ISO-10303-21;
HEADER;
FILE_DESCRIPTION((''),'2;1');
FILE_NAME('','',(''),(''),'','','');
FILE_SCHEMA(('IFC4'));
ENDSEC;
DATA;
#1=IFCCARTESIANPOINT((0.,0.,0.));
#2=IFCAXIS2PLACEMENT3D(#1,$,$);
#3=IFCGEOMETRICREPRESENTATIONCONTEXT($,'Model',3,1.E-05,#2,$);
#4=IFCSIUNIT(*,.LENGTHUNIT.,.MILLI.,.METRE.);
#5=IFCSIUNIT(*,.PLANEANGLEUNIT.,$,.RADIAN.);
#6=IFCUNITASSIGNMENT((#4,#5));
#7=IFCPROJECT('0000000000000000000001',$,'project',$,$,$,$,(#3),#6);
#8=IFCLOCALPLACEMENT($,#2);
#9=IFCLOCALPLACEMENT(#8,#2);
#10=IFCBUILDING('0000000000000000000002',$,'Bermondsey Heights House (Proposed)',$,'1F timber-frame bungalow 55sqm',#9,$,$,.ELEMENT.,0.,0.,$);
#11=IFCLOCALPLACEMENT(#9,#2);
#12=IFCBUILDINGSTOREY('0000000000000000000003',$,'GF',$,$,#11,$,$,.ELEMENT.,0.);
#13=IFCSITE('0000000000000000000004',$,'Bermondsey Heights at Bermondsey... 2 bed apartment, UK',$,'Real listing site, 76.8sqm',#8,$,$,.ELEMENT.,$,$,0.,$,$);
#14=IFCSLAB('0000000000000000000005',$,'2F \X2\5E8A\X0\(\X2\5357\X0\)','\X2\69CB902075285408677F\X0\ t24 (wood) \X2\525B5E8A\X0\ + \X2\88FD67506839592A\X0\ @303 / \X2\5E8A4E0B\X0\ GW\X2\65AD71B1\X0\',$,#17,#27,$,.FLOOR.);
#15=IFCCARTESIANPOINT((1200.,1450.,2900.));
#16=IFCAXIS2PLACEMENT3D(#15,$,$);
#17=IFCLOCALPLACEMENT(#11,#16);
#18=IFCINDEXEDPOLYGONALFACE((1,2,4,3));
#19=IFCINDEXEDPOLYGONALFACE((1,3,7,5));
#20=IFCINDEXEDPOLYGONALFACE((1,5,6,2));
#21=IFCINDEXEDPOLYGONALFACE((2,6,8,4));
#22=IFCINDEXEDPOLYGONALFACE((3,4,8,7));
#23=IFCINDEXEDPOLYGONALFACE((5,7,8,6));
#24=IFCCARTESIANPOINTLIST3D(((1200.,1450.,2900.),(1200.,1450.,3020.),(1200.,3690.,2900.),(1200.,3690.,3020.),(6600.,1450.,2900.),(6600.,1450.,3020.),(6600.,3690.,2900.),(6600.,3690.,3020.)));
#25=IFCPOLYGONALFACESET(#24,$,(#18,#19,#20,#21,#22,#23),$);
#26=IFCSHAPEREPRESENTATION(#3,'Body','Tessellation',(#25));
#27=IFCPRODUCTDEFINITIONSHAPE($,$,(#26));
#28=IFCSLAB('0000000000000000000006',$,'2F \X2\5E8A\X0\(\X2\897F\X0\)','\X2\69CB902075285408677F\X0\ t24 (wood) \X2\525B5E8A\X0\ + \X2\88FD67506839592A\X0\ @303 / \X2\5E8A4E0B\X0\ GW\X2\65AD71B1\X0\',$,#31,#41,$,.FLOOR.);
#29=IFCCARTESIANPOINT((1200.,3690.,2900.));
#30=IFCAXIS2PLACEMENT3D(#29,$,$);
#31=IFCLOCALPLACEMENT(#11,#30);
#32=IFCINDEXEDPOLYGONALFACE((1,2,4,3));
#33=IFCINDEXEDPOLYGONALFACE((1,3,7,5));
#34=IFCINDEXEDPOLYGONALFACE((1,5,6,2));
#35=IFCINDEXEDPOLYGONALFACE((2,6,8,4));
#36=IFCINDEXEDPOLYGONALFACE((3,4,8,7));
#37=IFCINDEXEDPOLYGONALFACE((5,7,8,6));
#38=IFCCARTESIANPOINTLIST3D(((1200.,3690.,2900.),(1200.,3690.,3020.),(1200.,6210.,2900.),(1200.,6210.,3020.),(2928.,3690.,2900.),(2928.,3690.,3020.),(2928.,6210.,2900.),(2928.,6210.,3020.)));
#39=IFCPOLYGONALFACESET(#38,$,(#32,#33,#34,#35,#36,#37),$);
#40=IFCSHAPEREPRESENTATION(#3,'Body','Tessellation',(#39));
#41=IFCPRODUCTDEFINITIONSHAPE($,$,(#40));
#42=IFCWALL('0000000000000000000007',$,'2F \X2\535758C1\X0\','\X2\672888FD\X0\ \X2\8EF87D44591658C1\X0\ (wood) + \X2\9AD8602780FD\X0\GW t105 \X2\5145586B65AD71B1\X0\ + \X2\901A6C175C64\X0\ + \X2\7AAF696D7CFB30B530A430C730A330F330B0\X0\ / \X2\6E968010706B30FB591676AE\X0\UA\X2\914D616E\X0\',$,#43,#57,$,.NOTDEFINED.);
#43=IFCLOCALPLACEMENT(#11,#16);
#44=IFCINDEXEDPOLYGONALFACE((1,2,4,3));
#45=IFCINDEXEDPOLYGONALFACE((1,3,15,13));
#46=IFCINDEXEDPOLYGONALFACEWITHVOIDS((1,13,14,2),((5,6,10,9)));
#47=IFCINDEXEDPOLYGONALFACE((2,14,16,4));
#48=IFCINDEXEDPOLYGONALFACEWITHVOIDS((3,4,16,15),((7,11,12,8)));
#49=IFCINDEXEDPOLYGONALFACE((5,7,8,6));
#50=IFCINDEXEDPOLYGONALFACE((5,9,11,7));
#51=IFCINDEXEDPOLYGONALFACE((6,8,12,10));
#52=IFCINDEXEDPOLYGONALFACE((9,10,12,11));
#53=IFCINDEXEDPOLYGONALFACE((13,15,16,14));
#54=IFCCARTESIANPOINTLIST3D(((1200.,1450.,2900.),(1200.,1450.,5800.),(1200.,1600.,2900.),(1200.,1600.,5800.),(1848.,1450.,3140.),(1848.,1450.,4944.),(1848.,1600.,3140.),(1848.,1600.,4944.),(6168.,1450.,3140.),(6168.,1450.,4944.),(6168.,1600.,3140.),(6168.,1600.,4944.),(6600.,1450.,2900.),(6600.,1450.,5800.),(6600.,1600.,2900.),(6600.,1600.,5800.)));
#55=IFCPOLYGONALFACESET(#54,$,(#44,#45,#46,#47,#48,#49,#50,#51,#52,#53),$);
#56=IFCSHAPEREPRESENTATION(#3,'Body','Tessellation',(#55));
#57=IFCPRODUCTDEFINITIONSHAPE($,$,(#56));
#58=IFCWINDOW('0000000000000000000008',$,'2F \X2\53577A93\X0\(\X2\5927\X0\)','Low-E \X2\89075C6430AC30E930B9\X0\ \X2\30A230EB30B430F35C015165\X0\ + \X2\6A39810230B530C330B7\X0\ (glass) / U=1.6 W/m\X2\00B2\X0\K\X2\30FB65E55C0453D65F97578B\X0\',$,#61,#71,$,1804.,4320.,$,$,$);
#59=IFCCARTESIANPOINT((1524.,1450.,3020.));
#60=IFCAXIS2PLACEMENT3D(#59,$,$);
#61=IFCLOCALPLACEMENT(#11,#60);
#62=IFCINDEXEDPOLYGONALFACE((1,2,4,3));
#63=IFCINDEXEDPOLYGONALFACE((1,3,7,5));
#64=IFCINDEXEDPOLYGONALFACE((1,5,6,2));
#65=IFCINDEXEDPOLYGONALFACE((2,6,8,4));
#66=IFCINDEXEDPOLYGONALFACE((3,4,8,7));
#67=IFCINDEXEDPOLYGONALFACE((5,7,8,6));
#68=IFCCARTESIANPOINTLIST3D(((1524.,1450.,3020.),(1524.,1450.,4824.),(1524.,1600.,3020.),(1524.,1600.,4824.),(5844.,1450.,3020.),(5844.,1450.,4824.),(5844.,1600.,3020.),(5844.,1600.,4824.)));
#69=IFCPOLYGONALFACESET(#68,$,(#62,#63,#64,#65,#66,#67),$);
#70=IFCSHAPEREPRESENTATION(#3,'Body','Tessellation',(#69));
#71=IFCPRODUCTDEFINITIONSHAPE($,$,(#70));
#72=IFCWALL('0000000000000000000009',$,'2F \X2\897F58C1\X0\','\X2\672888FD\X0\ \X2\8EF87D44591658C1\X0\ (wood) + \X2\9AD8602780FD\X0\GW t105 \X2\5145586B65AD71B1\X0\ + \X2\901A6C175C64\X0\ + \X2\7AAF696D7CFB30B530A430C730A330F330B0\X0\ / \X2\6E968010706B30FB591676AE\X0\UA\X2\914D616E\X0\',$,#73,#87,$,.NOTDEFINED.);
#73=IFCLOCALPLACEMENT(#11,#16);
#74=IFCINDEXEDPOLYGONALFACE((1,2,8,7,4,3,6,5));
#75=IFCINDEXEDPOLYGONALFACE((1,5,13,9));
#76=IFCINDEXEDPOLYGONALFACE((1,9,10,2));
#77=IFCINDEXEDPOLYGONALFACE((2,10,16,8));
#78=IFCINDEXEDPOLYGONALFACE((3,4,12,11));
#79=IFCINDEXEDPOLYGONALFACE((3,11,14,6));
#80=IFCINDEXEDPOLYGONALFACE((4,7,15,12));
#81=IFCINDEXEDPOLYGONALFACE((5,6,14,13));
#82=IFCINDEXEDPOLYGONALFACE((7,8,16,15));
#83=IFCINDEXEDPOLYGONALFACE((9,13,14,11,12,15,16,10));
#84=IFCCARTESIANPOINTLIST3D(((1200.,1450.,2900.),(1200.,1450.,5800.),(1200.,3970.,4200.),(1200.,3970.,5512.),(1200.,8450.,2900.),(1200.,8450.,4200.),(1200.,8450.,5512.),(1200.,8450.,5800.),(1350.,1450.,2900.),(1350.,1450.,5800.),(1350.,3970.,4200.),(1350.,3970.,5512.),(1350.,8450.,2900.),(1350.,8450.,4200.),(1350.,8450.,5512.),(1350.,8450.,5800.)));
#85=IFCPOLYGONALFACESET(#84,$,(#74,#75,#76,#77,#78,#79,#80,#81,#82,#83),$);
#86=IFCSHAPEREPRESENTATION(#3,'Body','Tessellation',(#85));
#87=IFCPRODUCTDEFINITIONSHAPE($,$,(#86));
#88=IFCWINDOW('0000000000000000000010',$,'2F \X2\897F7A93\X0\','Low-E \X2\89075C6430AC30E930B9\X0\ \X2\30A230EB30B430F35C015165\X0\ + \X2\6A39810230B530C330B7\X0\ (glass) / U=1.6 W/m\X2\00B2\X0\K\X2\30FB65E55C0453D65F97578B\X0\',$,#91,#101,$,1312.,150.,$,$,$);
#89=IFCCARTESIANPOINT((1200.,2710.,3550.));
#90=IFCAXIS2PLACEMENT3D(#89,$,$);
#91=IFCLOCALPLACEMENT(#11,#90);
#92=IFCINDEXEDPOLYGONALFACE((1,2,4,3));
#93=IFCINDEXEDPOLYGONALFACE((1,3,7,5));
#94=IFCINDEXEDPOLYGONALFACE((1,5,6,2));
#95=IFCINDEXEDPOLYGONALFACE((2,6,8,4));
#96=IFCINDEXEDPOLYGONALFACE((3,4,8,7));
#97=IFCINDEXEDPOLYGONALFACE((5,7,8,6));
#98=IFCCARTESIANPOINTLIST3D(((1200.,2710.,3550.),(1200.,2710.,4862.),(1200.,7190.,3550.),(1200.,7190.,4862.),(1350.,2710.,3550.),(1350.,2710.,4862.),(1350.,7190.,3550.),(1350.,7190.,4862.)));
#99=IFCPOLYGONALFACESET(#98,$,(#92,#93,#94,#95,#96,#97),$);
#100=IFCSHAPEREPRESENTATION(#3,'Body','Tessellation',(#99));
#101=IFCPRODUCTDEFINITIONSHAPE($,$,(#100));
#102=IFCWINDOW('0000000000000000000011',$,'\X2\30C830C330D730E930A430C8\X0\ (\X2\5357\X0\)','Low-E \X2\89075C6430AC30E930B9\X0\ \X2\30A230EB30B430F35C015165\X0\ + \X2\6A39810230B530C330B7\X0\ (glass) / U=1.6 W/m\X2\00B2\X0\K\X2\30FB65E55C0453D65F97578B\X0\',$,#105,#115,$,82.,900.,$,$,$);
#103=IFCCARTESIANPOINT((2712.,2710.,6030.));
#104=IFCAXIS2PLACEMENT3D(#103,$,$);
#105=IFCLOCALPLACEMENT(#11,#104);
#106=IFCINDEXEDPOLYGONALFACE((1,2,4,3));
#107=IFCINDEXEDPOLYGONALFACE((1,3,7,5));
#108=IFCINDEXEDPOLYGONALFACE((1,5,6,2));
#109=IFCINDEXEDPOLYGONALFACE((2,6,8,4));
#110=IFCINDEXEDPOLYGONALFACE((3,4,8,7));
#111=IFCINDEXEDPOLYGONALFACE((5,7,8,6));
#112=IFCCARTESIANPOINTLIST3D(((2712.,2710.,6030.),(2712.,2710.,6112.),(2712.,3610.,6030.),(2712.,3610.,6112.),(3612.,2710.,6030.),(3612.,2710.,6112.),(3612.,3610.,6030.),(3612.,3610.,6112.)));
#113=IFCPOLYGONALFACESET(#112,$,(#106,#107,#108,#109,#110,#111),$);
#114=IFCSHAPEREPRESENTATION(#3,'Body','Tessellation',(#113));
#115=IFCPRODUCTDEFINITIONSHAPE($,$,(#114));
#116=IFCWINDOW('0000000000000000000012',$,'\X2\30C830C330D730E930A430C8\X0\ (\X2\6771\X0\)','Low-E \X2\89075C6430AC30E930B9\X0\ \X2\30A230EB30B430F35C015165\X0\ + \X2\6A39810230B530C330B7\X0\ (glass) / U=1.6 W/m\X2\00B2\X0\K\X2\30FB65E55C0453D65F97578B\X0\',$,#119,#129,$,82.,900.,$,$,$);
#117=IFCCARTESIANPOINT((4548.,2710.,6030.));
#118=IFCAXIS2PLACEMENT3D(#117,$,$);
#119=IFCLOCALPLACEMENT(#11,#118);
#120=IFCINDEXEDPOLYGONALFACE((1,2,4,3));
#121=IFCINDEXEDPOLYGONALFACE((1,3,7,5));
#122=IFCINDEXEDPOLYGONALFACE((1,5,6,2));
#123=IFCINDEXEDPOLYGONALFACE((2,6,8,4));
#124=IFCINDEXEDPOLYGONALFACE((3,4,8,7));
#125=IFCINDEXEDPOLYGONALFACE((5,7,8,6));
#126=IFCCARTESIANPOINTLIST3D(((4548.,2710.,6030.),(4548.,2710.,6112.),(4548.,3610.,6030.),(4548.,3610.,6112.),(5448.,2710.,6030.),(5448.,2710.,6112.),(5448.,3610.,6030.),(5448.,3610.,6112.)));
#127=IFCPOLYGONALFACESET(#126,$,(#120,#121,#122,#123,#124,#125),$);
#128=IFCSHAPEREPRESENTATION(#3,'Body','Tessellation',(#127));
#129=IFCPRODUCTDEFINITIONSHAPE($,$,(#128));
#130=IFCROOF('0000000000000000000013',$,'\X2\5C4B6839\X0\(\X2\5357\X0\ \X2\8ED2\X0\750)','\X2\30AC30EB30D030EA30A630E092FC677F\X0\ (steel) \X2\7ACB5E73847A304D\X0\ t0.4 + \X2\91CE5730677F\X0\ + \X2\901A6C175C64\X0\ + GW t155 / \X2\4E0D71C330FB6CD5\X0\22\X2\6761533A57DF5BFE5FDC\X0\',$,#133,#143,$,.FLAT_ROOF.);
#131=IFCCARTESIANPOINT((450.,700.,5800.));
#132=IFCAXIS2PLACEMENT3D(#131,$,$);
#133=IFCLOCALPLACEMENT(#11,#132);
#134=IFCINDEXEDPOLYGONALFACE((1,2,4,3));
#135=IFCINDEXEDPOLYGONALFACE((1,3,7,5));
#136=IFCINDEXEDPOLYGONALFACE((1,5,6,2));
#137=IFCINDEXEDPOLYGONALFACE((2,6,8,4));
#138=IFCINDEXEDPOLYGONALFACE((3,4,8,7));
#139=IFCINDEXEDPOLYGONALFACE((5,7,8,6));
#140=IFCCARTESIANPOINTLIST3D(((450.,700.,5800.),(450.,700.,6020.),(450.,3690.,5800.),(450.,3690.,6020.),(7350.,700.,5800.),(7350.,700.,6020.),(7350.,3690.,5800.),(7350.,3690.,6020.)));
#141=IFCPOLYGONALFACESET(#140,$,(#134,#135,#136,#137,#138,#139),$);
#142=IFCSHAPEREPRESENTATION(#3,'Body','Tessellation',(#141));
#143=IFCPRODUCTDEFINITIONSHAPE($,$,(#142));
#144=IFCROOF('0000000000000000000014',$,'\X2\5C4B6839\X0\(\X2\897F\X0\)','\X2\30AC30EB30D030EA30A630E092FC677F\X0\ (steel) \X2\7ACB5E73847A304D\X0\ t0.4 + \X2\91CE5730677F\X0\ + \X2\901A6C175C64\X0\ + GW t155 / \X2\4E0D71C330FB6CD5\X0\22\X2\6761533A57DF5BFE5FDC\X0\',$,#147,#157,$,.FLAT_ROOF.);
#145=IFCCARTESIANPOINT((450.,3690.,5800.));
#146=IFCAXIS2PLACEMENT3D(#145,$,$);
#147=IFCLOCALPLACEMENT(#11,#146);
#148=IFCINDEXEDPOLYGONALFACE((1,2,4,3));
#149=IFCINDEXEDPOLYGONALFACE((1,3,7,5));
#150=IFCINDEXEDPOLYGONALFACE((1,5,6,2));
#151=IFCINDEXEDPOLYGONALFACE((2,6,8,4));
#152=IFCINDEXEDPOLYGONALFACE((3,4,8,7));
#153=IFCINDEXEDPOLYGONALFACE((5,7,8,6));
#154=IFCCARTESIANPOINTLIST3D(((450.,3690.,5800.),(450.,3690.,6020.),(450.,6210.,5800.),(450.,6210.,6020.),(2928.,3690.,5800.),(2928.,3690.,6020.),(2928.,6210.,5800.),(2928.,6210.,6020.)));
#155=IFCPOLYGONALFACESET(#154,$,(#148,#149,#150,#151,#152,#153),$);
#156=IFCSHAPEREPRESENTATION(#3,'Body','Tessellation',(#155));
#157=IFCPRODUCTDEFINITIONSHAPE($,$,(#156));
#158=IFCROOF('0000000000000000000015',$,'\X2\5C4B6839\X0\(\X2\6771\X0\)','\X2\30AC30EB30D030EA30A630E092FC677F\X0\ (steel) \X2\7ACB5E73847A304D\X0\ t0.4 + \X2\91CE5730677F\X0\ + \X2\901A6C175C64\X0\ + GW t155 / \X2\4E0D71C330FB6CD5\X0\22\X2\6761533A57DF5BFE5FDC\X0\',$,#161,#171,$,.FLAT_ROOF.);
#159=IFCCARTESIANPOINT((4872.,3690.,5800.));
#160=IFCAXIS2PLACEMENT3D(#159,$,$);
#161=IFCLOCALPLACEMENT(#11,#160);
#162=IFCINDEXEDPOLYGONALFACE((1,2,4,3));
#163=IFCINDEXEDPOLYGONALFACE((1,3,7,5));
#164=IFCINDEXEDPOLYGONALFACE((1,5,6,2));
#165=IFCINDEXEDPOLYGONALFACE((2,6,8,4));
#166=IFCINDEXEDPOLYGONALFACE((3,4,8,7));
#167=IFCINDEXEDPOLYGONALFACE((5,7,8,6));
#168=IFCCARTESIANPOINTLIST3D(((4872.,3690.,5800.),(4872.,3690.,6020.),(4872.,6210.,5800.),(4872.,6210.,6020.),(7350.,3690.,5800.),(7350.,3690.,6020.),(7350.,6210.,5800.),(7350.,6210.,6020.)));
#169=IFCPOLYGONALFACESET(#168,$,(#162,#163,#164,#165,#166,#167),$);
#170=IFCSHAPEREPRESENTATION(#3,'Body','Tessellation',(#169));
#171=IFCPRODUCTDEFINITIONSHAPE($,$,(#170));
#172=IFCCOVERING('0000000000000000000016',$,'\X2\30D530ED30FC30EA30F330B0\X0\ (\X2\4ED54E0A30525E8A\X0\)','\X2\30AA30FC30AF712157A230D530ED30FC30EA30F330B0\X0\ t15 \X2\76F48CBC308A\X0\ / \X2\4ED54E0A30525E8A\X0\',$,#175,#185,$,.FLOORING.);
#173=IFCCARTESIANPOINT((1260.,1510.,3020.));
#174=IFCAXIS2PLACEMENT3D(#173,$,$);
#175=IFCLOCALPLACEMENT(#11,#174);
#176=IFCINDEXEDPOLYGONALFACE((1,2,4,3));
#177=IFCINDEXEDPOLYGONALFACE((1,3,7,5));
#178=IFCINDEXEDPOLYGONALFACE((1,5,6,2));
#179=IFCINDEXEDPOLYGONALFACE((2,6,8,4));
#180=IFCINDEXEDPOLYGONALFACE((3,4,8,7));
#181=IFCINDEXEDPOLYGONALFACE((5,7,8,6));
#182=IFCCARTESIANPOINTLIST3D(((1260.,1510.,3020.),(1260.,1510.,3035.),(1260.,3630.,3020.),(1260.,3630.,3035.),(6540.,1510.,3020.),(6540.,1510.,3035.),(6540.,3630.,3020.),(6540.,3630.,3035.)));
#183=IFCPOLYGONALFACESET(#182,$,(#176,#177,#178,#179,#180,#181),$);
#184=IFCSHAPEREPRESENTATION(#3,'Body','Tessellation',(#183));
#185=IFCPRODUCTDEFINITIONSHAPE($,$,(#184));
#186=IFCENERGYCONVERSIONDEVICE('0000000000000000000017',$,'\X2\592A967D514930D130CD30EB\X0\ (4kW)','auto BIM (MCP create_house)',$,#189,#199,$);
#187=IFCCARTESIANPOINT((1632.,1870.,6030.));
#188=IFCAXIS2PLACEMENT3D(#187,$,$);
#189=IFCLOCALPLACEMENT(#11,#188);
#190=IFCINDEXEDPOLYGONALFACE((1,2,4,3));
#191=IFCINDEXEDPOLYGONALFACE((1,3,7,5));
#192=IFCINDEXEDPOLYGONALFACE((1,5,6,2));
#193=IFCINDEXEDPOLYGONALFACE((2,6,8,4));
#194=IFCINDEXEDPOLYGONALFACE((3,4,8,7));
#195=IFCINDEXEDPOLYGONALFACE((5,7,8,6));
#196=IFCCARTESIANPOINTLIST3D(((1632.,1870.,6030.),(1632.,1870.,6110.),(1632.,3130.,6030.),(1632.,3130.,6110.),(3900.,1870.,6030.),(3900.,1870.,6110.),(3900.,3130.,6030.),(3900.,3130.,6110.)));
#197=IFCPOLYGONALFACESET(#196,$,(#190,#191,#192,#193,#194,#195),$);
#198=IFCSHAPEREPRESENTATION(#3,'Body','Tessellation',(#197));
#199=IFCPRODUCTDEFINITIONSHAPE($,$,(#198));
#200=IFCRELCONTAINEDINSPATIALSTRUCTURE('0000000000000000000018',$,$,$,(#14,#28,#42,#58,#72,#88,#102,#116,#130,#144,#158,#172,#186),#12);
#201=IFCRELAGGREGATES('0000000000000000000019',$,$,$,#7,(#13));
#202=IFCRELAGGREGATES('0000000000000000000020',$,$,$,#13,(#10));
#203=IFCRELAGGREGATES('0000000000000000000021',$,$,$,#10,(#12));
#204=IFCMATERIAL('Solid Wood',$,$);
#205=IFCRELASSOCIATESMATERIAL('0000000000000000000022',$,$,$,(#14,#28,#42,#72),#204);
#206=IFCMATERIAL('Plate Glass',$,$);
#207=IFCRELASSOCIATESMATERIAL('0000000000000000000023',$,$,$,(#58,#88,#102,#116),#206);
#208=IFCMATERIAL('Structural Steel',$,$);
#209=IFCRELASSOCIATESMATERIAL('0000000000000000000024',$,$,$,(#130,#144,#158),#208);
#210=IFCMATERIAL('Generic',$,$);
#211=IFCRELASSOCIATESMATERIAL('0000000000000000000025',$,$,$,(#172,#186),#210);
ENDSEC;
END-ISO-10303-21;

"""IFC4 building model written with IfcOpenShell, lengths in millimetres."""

from ifc_helpers import new_model, si_unit, frame, frame_2d, origin, place, context, project, spatial, rectangle, extrude, material, element, fill, save


model = new_model("IFC4")

# Units and contexts
model_context = context("Model", 3, precision=1e-05, world=origin())
ifc_project = project(units=[si_unit("LENGTHUNIT", "METRE", prefix="MILLI"), si_unit("PLANEANGLEUNIT", "RADIAN")], contexts=[model_context])

# Site, building, storey
site_placement = place(None, origin())
site = spatial("IfcSite", under=ifc_project, at=site_placement, Name="Bermondsey Heights at Bermondsey... 2 bed apartment, UK", ObjectType="Real listing site, 76.8sqm", CompositionType="ELEMENT", RefElevation=0.0)
building_placement = place(site_placement, origin())
building = spatial("IfcBuilding", under=site, at=building_placement, Name="Bermondsey Heights House (Proposed)", ObjectType="1F timber-frame bungalow 55sqm", CompositionType="ELEMENT", ElevationOfRefHeight=0.0, ElevationOfTerrain=0.0)
storey_placement = place(building_placement, origin())
storey = spatial("IfcBuildingStorey", under=building, at=storey_placement, Name="GF", CompositionType="ELEMENT", Elevation=0.0)

# Slabs
ifc_material_1 = material(Name="Solid Wood")
slab_1_placement = place(storey_placement, frame((1200.0, 1450.0, 2900.0)))
element("IfcSlab", 1, at=slab_1_placement, inside=storey, material=ifc_material_1, Name="2F 床(南)", Description="構造用合板 t24 (wood) 剛床 + 製材根太 @303 / 床下 GW断熱", PredefinedType="FLOOR", context=model_context, shape_type="SweptSolid", body=[
    extrude(rectangle(XDim=5400.0, YDim=2240.0, at=frame_2d((2700.0, 1120.0))), frame((1200.0, 1450.0, 2900.0)), (0.0, 0.0, 1.0), 120.0),
])
slab_2_placement = place(storey_placement, frame((1200.0, 3690.0, 2900.0)))
element("IfcSlab", 2, at=slab_2_placement, inside=storey, material=ifc_material_1, Name="2F 床(西)", Description="構造用合板 t24 (wood) 剛床 + 製材根太 @303 / 床下 GW断熱", PredefinedType="FLOOR", context=model_context, shape_type="SweptSolid", body=[
    extrude(rectangle(XDim=1728.0, YDim=2520.0, at=frame_2d((864.0, 1260.0))), frame((1200.0, 3690.0, 2900.0)), (0.0, 0.0, 1.0), 120.0),
])

# Walls, openings, windows
wall_1_placement = place(storey_placement, frame((1200.0, 1450.0, 2900.0)))
wall_1 = element("IfcWall", 3, at=wall_1_placement, inside=storey, material=ifc_material_1, Name="2F 南壁", Description="木製 軸組外壁 (wood) + 高性能GW t105 充填断熱 + 通気層 + 窯業系サイディング / 準耐火・外皮UA配慮", PredefinedType="NOTDEFINED", context=model_context, shape_type="SweptSolid", body=[
    extrude(rectangle(XDim=5400.0, YDim=150.0, at=frame_2d((2700.0, 75.0))), frame((1200.0, 1450.0, 2900.0)), (0.0, 0.0, 1.0), 2900.0),
])
opening_1_placement = place(storey_placement, frame((1524.0, 1450.0, 3020.0)))
opening_1 = element("IfcOpeningElement", 4, at=opening_1_placement, cuts=wall_1, PredefinedType="NOTDEFINED", context=model_context, shape_type="SweptSolid", body=[
    extrude(rectangle(XDim=4320.0, YDim=150.0, at=frame_2d((2160.0, 75.0))), frame((1524.0, 1450.0, 3020.0)), (0.0, 0.0, 1.0), 1804.0),
])
ifc_material_2 = material(Name="Plate Glass")
window_1_placement = place(storey_placement, frame((1524.0, 1450.0, 3020.0)))
window_1 = element("IfcWindow", 5, at=window_1_placement, inside=storey, material=ifc_material_2, Name="2F 南窓(大)", Description="Low-E 複層ガラス アルゴン封入 + 樹脂サッシ (glass) / U=1.6 W/m²K・日射取得型", OverallHeight=1804.0, OverallWidth=4320.0, context=model_context, shape_type="SweptSolid", body=[
    extrude(rectangle(XDim=4320.0, YDim=150.0, at=frame_2d((2160.0, 75.0))), frame((1524.0, 1450.0, 3020.0)), (0.0, 0.0, 1.0), 1804.0),
])
fill(opening_1, window_1)
wall_2_placement = place(storey_placement, frame((1200.0, 1450.0, 2900.0)))
wall_2 = element("IfcWall", 6, at=wall_2_placement, inside=storey, material=ifc_material_1, Name="2F 西壁", Description="木製 軸組外壁 (wood) + 高性能GW t105 充填断熱 + 通気層 + 窯業系サイディング / 準耐火・外皮UA配慮", PredefinedType="NOTDEFINED", context=model_context, shape_type="SweptSolid", body=[
    extrude(rectangle(XDim=150.0, YDim=7000.0, at=frame_2d((75.0, 3500.0))), frame((1200.0, 1450.0, 2900.0)), (0.0, 0.0, 1.0), 2900.0),
])
opening_2_placement = place(storey_placement, frame((1200.0, 2710.0, 3550.0)))
opening_2 = element("IfcOpeningElement", 7, at=opening_2_placement, cuts=wall_2, PredefinedType="NOTDEFINED", context=model_context, shape_type="SweptSolid", body=[
    extrude(rectangle(XDim=150.0, YDim=4480.0, at=frame_2d((75.0, 2240.0))), frame((1200.0, 2710.0, 3550.0)), (0.0, 0.0, 1.0), 1312.0),
])
window_2_placement = place(storey_placement, frame((1200.0, 2710.0, 3550.0)))
window_2 = element("IfcWindow", 8, at=window_2_placement, inside=storey, material=ifc_material_2, Name="2F 西窓", Description="Low-E 複層ガラス アルゴン封入 + 樹脂サッシ (glass) / U=1.6 W/m²K・日射取得型", OverallHeight=1312.0, OverallWidth=150.0, context=model_context, shape_type="SweptSolid", body=[
    extrude(rectangle(XDim=150.0, YDim=4480.0, at=frame_2d((75.0, 2240.0))), frame((1200.0, 2710.0, 3550.0)), (0.0, 0.0, 1.0), 1312.0),
])
fill(opening_2, window_2)

# Windows
window_3_placement = place(storey_placement, frame((2712.0, 2710.0, 6030.0)))
element("IfcWindow", 9, at=window_3_placement, inside=storey, material=ifc_material_2, Name="トップライト (南)", Description="Low-E 複層ガラス アルゴン封入 + 樹脂サッシ (glass) / U=1.6 W/m²K・日射取得型", OverallHeight=82.0, OverallWidth=900.0, context=model_context, shape_type="SweptSolid", body=[
    extrude(rectangle(XDim=900.0, YDim=900.0, at=frame_2d((450.0, 450.0))), frame((2712.0, 2710.0, 6030.0)), (0.0, 0.0, 1.0), 82.0),
])
window_4_placement = place(storey_placement, frame((4548.0, 2710.0, 6030.0)))
element("IfcWindow", 10, at=window_4_placement, inside=storey, material=ifc_material_2, Name="トップライト (東)", Description="Low-E 複層ガラス アルゴン封入 + 樹脂サッシ (glass) / U=1.6 W/m²K・日射取得型", OverallHeight=82.0, OverallWidth=900.0, context=model_context, shape_type="SweptSolid", body=[
    extrude(rectangle(XDim=900.0, YDim=900.0, at=frame_2d((450.0, 450.0))), frame((4548.0, 2710.0, 6030.0)), (0.0, 0.0, 1.0), 82.0),
])

# Roofs
ifc_material_3 = material(Name="Structural Steel")
roof_1_placement = place(storey_placement, frame((450.0, 700.0, 5800.0)))
element("IfcRoof", 11, at=roof_1_placement, inside=storey, material=ifc_material_3, Name="屋根(南 軒750)", Description="ガルバリウム鋼板 (steel) 立平葺き t0.4 + 野地板 + 通気層 + GW t155 / 不燃・法22条区域対応", PredefinedType="FLAT_ROOF", context=model_context, shape_type="SweptSolid", body=[
    extrude(rectangle(XDim=6900.0, YDim=2990.0, at=frame_2d((3450.0, 1495.0))), frame((450.0, 700.0, 5800.0)), (0.0, 0.0, 1.0), 220.0),
])
roof_2_placement = place(storey_placement, frame((450.0, 3690.0, 5800.0)))
element("IfcRoof", 12, at=roof_2_placement, inside=storey, material=ifc_material_3, Name="屋根(西)", Description="ガルバリウム鋼板 (steel) 立平葺き t0.4 + 野地板 + 通気層 + GW t155 / 不燃・法22条区域対応", PredefinedType="FLAT_ROOF", context=model_context, shape_type="SweptSolid", body=[
    extrude(rectangle(XDim=2478.0, YDim=2520.0, at=frame_2d((1239.0, 1260.0))), frame((450.0, 3690.0, 5800.0)), (0.0, 0.0, 1.0), 220.0),
])
roof_3_placement = place(storey_placement, frame((4872.0, 3690.0, 5800.0)))
element("IfcRoof", 13, at=roof_3_placement, inside=storey, material=ifc_material_3, Name="屋根(東)", Description="ガルバリウム鋼板 (steel) 立平葺き t0.4 + 野地板 + 通気層 + GW t155 / 不燃・法22条区域対応", PredefinedType="FLAT_ROOF", context=model_context, shape_type="SweptSolid", body=[
    extrude(rectangle(XDim=2478.0, YDim=2520.0, at=frame_2d((1239.0, 1260.0))), frame((4872.0, 3690.0, 5800.0)), (0.0, 0.0, 1.0), 220.0),
])

# Covering
ifc_material_4 = material(Name="Generic")
covering_placement = place(storey_placement, frame((1260.0, 1510.0, 3020.0)))
element("IfcCovering", 14, at=covering_placement, inside=storey, material=ifc_material_4, Name="フローリング (仕上げ床)", Description="オーク無垢フローリング t15 直貼り / 仕上げ床", PredefinedType="FLOORING", context=model_context, shape_type="SweptSolid", body=[
    extrude(rectangle(XDim=5280.0, YDim=2120.0, at=frame_2d((2640.0, 1060.0))), frame((1260.0, 1510.0, 3020.0)), (0.0, 0.0, 1.0), 15.0),
])

# Energy conversion device
energy_conversion_device_placement = place(storey_placement, frame((1632.0, 1870.0, 6030.0)))
element("IfcEnergyConversionDevice", 15, at=energy_conversion_device_placement, inside=storey, material=ifc_material_4, Name="太陽光パネル (4kW)", Description="auto BIM (MCP create_house)", context=model_context, shape_type="SweptSolid", body=[
    extrude(rectangle(XDim=2268.0, YDim=1260.0, at=frame_2d((1134.0, 630.0))), frame((1632.0, 1870.0, 6030.0)), (0.0, 0.0, 1.0), 80.0),
])

save(model, "model.ifc")
